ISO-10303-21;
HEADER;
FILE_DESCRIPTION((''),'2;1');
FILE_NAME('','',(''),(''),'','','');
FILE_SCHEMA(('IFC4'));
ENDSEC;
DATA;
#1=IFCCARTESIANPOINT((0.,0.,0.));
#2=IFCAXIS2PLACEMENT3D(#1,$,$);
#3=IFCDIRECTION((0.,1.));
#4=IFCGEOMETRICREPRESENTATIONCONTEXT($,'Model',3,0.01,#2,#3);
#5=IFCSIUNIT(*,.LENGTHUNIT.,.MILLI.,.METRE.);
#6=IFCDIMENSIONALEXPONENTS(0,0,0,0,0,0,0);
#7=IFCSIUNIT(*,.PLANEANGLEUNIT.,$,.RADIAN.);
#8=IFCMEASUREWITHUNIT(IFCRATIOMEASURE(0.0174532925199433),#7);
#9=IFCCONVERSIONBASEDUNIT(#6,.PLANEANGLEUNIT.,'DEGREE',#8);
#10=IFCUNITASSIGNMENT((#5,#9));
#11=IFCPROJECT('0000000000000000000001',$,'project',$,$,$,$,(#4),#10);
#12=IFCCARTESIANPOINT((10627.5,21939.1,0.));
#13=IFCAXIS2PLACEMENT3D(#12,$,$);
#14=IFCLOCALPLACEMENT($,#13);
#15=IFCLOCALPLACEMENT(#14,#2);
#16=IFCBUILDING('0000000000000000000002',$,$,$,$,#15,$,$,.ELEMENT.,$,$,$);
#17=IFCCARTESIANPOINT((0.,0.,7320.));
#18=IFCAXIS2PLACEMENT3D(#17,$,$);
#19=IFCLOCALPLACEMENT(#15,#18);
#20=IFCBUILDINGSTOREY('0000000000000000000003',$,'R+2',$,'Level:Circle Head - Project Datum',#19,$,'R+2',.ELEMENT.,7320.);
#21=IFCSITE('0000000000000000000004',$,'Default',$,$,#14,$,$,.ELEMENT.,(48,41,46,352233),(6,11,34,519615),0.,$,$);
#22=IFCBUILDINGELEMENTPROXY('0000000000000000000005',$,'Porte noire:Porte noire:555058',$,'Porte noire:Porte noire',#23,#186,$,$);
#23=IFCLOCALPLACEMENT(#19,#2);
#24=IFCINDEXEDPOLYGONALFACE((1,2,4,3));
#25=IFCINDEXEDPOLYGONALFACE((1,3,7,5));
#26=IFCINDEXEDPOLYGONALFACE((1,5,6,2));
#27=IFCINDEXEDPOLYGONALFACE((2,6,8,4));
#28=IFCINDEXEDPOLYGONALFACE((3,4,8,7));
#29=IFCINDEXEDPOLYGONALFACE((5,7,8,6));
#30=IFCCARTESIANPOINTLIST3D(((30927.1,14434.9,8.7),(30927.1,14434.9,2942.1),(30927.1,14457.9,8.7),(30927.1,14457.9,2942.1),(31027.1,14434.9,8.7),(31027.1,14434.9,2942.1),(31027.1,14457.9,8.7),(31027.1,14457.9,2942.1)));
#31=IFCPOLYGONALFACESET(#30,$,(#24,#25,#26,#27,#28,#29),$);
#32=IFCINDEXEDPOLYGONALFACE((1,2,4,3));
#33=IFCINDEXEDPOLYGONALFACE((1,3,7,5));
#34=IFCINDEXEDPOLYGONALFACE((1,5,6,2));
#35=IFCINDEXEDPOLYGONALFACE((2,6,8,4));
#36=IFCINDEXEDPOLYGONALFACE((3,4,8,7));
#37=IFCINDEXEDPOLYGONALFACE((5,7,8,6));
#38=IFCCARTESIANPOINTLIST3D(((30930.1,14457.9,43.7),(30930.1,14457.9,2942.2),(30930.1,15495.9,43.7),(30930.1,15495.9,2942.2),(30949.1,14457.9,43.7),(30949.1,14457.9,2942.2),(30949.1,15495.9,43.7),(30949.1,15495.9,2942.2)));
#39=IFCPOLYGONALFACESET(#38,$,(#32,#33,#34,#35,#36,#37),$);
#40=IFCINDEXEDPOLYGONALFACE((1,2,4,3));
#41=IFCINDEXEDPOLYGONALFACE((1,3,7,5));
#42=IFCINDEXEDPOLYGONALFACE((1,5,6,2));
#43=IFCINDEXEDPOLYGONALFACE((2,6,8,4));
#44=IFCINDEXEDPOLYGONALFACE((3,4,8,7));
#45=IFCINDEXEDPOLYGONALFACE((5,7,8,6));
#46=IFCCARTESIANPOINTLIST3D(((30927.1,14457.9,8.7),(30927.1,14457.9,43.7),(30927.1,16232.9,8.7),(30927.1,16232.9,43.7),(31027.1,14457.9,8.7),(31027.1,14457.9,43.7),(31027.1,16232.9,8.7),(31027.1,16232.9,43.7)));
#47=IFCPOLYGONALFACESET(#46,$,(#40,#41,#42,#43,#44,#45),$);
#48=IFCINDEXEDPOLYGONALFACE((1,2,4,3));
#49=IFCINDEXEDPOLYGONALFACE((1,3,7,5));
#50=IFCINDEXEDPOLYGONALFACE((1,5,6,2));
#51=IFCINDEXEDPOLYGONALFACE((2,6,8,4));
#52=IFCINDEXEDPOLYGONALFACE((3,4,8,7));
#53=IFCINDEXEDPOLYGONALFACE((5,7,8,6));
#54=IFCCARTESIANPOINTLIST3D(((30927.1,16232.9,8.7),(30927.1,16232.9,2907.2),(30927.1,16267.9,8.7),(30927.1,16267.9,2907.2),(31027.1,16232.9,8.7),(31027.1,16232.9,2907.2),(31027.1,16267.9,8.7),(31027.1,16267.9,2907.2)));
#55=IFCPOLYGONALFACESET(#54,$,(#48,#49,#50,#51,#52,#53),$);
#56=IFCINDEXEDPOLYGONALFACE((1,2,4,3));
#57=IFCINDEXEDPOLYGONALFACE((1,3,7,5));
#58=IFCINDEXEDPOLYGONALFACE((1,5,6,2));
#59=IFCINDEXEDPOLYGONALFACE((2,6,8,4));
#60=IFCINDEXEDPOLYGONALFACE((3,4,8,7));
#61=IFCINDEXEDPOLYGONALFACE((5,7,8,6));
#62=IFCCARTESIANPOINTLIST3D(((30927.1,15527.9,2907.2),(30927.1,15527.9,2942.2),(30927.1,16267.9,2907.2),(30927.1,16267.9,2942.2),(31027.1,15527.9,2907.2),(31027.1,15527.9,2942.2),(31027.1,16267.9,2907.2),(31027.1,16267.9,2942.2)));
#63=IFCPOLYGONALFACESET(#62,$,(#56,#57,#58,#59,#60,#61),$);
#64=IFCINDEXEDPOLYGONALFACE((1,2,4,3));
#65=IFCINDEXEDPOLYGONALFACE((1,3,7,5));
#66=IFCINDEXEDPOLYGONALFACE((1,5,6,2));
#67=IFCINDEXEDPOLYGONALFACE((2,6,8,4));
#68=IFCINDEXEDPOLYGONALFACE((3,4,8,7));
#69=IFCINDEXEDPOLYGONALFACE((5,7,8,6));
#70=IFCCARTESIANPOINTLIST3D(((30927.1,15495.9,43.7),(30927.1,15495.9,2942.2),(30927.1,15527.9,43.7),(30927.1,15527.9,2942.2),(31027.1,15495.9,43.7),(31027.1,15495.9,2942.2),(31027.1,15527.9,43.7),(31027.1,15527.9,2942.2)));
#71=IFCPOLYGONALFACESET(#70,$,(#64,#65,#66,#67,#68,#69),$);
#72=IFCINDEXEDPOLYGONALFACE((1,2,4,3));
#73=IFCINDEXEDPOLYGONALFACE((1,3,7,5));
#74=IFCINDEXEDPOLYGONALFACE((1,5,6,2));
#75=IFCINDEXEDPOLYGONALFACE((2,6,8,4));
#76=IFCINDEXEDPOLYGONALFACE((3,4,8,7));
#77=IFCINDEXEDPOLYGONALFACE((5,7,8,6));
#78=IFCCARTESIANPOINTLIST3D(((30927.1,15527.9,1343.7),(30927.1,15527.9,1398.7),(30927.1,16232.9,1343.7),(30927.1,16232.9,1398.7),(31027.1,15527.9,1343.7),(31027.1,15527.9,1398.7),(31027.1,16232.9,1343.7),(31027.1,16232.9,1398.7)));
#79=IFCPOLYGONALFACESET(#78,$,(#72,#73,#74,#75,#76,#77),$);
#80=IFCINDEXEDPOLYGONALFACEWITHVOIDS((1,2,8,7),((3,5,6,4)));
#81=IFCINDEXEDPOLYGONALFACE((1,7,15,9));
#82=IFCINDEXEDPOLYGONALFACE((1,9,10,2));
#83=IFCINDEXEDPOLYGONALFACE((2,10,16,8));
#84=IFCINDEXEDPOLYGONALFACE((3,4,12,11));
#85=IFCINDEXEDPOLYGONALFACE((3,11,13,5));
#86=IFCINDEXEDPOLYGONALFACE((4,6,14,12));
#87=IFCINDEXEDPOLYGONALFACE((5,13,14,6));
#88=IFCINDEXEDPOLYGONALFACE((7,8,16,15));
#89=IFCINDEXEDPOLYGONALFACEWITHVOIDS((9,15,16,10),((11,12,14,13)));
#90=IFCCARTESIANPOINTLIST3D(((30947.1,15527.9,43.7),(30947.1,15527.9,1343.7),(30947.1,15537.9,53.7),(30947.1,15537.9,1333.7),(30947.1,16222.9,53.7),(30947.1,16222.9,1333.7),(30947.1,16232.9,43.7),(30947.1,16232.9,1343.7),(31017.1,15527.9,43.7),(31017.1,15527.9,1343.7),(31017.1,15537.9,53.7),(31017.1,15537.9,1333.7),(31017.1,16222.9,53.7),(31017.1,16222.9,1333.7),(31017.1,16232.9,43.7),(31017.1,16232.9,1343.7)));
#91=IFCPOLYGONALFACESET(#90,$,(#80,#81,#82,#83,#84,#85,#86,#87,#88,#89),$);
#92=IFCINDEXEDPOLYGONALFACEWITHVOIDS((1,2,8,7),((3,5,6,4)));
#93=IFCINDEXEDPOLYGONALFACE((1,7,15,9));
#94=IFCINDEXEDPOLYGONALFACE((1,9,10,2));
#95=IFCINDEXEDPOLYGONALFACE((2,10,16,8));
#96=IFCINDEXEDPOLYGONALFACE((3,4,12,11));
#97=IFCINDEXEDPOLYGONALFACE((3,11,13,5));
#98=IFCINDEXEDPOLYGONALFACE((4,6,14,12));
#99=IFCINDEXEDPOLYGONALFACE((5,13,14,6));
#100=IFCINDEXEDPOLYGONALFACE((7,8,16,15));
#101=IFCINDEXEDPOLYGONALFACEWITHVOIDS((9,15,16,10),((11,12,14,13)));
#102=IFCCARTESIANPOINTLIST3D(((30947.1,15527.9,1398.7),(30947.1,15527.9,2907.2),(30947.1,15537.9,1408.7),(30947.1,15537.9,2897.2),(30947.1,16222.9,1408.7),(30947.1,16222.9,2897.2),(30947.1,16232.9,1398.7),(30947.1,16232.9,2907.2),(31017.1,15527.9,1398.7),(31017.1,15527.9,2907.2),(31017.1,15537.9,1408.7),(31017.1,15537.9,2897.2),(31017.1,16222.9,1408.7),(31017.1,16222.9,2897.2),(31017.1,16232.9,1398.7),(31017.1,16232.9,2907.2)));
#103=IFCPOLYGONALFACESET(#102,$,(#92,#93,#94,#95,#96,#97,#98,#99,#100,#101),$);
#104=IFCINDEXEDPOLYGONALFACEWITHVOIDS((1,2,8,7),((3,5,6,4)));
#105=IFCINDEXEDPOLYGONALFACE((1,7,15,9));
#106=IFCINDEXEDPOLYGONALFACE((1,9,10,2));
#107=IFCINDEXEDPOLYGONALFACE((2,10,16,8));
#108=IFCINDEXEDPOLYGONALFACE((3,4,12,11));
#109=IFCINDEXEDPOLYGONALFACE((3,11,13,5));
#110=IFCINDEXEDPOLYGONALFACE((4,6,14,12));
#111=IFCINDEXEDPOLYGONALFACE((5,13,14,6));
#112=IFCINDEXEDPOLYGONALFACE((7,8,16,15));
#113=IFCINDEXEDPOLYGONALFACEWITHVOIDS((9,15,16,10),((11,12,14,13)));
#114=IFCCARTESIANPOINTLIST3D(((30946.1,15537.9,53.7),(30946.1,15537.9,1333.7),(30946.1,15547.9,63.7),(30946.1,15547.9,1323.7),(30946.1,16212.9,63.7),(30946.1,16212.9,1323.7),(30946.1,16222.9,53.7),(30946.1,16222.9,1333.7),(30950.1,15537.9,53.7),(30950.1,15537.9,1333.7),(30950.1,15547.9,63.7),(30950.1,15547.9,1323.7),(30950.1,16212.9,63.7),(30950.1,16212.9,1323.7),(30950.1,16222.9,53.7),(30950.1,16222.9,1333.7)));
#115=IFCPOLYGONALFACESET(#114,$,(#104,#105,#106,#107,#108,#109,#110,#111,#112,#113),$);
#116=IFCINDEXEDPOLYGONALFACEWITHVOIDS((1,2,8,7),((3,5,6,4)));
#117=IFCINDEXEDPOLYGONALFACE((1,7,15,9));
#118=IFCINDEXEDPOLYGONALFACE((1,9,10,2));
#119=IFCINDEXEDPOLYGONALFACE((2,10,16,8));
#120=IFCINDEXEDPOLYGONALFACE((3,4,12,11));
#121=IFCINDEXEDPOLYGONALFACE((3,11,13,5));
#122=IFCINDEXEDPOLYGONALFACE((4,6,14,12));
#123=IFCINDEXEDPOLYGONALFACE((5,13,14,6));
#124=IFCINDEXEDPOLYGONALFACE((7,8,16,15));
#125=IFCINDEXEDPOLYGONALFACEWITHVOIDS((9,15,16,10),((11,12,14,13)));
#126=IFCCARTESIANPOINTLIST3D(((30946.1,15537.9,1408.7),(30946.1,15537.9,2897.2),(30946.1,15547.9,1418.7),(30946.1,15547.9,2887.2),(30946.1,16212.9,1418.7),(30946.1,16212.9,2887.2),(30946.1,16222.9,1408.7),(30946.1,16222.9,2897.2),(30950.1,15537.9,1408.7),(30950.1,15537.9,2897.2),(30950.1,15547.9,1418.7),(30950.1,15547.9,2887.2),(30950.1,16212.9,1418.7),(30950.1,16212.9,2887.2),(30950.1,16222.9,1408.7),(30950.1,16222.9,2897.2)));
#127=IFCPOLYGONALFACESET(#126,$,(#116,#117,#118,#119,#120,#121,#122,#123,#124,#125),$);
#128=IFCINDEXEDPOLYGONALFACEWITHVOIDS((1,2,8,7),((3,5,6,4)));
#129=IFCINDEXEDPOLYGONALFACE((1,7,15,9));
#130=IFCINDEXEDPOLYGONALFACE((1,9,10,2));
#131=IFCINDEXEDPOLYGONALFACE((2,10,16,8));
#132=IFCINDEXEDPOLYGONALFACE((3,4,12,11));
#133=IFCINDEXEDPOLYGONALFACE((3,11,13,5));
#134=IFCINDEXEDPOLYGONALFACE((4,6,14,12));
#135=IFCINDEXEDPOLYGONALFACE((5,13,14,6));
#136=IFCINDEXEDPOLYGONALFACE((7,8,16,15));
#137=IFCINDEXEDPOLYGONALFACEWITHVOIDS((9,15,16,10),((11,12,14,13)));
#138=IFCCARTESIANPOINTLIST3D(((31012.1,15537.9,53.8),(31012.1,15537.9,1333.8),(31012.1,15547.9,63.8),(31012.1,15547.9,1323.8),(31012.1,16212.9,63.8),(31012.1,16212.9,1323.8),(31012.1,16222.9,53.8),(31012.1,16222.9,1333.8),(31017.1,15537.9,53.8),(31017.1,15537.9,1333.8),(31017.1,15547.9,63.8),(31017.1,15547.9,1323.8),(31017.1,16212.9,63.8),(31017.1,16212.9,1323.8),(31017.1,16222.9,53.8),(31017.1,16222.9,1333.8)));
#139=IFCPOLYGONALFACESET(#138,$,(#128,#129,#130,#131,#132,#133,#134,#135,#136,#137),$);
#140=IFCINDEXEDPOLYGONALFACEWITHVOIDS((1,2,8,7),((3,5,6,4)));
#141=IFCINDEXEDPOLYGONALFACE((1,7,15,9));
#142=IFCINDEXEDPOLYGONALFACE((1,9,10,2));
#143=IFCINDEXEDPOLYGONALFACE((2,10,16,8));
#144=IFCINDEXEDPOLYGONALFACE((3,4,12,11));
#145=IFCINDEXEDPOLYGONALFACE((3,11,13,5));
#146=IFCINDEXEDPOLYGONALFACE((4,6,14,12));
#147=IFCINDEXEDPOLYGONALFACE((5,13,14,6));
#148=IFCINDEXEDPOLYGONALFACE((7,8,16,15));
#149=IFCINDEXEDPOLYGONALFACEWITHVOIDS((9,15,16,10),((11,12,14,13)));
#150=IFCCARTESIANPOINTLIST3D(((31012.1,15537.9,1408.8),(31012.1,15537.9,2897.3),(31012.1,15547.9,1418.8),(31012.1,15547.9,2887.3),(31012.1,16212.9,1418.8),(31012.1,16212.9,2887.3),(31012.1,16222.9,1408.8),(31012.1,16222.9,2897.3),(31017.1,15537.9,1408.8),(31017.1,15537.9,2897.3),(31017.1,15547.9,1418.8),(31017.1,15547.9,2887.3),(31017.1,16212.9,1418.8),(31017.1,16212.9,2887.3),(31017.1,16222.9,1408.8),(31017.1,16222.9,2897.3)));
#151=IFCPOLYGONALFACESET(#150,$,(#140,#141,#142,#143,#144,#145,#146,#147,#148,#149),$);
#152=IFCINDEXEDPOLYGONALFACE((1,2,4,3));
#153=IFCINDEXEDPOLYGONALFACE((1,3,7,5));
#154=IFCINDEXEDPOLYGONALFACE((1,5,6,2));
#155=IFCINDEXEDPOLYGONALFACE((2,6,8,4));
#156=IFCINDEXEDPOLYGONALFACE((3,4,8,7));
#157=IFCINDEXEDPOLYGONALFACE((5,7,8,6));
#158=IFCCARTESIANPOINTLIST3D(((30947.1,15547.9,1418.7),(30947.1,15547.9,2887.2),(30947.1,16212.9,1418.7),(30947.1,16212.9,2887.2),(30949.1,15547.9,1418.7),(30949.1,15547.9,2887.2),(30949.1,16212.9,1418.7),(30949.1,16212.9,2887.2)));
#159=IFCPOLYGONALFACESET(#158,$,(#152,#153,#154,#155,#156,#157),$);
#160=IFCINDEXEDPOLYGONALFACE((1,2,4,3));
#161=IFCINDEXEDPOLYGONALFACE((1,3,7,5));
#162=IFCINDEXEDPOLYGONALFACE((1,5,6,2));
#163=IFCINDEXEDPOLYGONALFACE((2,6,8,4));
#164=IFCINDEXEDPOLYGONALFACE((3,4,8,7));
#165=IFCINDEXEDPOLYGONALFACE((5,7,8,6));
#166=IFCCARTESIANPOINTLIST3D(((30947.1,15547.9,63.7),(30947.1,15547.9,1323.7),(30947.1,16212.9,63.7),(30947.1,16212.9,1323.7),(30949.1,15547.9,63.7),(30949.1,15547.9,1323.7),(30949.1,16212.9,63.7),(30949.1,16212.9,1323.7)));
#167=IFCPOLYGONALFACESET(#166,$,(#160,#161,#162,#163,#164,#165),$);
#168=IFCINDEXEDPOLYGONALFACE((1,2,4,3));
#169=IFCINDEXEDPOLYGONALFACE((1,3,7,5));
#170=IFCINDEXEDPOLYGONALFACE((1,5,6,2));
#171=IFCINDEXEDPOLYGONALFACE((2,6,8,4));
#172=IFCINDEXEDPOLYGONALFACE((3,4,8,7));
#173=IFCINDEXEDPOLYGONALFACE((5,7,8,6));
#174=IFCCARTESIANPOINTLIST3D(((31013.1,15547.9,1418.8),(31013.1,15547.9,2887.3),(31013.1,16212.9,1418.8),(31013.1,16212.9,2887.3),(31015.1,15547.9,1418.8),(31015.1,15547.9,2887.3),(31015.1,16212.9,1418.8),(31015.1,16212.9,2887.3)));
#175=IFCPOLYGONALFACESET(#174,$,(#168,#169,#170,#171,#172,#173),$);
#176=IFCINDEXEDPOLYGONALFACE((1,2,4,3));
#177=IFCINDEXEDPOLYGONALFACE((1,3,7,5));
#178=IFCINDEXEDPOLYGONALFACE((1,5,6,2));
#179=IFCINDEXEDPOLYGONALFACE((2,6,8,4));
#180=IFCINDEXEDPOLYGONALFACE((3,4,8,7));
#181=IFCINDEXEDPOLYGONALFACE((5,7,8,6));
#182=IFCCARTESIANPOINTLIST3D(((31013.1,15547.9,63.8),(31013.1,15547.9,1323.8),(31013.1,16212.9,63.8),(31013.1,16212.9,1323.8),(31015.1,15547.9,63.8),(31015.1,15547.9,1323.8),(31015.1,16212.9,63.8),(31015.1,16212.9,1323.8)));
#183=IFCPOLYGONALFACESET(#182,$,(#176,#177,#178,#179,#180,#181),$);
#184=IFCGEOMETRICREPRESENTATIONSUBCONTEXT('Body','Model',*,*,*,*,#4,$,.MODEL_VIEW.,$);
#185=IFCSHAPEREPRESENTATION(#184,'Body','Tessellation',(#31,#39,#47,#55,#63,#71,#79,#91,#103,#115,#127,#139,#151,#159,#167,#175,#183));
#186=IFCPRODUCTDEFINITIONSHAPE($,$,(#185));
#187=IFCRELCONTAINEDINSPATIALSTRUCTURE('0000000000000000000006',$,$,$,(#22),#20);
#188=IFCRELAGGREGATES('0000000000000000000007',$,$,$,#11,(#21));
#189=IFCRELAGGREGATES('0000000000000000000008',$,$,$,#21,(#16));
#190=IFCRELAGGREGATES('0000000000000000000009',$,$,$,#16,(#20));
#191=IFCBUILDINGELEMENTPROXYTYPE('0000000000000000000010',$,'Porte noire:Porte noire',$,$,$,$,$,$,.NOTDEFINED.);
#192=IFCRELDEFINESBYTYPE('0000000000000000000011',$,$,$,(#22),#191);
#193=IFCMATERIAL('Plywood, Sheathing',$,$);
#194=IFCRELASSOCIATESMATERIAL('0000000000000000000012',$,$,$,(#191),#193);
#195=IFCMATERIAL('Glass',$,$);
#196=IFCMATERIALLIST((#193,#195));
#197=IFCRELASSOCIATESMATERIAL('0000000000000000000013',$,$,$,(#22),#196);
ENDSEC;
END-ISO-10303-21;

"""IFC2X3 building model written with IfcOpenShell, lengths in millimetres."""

from ifc_helpers import new_model, entity, si_unit, converted_unit, direction, frame, frame_2d, origin, origin_2d_with_axis, place, context, subcontext, project, spatial, polyline, rectangle, outline, extrude, source, transform, mapped, material, material_list, type_object, type_shapes, element, save


model = new_model("IFC2X3")

# Units and contexts
model_context = context("Model", 3, precision=0.01, world=origin(), true_north=direction((0.0, 1.0)))
body_context = subcontext(model_context, "Body", "Model", "MODEL_VIEW")
ifc_project = project(units=[si_unit("LENGTHUNIT", "METRE", prefix="MILLI"), converted_unit("PLANEANGLEUNIT", "DEGREE", entity("IfcRatioMeasure", 0.0174532925199433), si_unit("PLANEANGLEUNIT", "RADIAN"), dimensions=[0, 0, 0, 0, 0, 0, 0])], contexts=[model_context])

# Site, building, storey
site_placement = place(None, frame((10627.5, 21939.1, 0.0)))
site = spatial("IfcSite", under=ifc_project, at=site_placement, Name="Default", CompositionType="ELEMENT", RefLatitude=(48, 41, 46, 352233), RefLongitude=(6, 11, 34, 519615), RefElevation=0.0)
building_placement = place(site_placement, origin())
building = spatial("IfcBuilding", under=site, at=building_placement, CompositionType="ELEMENT")
storey_placement = place(building_placement, frame((0.0, 0.0, 7320.0)))
storey = spatial("IfcBuildingStorey", under=building, at=storey_placement, Name="R+2", ObjectType="Level:Circle Head - Project Datum", LongName="R+2", CompositionType="ELEMENT", Elevation=7320.0)

# Building element proxy
ifc_material_1 = material(Name="Glass")
ifc_material_2 = material(Name="Plywood, Sheathing")
building_element_proxy_type_1 = type_object("IfcBuildingElementProxyType", Name="Porte noire:Porte noire", PredefinedType="NOTDEFINED", material=ifc_material_2)
shared_shape_1 = source(origin(), body_context, "Body", "SweptSolid", [
    extrude(rectangle(XDim=23.0, YDim=100.0, at=frame_2d((0.0, 0.0), x_axis=(1.0, 0.0))), frame((-950.9, 50.0, 8.7), z_axis=(0.0, 0.0, 1.0), x_axis=(-1.0, 0.0, 0.0)), (0.0, 0.0, 1.0), 2933.3),
    extrude(rectangle(XDim=1038.0, YDim=19.0, at=frame_2d((0.0, 0.0), x_axis=(1.0, 0.0))), frame((-420.4, 87.5, 43.7), z_axis=(0.0, 0.0, 1.0), x_axis=(-1.0, 0.0, 0.0)), (0.0, 0.0, 1.0), 2898.5),
    extrude(rectangle(XDim=1775.0, YDim=100.0, at=origin_2d_with_axis()), frame((-51.9, 50.0, 8.7), z_axis=(0.0, 0.0, 1.0), x_axis=(-1.0, 0.0, 0.0)), (0.0, 0.0, 1.0), 35.0),
    extrude(rectangle(XDim=35.0, YDim=100.0, at=origin_2d_with_axis()), frame((853.1, 50.0, 8.7), z_axis=(0.0, 0.0, 1.0), x_axis=(-1.0, 0.0, 0.0)), (0.0, 0.0, 1.0), 2898.5),
    extrude(rectangle(XDim=740.0, YDim=100.0, at=origin_2d_with_axis()), frame((500.6, 50.0, 2907.2), z_axis=(0.0, 0.0, 1.0), x_axis=(-1.0, 0.0, 0.0)), (0.0, 0.0, 1.0), 35.0),
    extrude(rectangle(XDim=32.0, YDim=100.0, at=origin_2d_with_axis()), frame((114.6, 50.0, 43.7), z_axis=(0.0, 0.0, 1.0), x_axis=(-1.0, 0.0, 0.0)), (0.0, 0.0, 1.0), 2898.5),
    extrude(rectangle(XDim=705.0, YDim=100.0, at=origin_2d_with_axis()), frame((483.1, 50.0, 1343.7), z_axis=(0.0, 0.0, 1.0), x_axis=(-1.0, 0.0, 0.0)), (0.0, 0.0, 1.0), 55.0),
    extrude(outline(polyline([(-352.5, -650.0), (352.5, -650.0), (352.5, 650.0), (-352.5, 650.0), (-352.5, -650.0)]), holes=[polyline([(342.5, 640.0), (342.5, -640.0), (-342.5, -640.0), (-342.5, 640.0), (342.5, 640.0)])]), frame((483.1, 10.0, 693.7), z_axis=(0.0, 1.0, 0.0), x_axis=(1.0, 0.0, 0.0)), (0.0, 0.0, 1.0), 70.0),
    extrude(outline(polyline([(-754.2, -352.5), (754.2, -352.5), (754.2, 352.5), (-754.2, 352.5), (-754.2, -352.5)]), holes=[polyline([(744.2, 342.5), (744.2, -342.5), (-744.2, -342.5), (-744.2, 342.5), (744.2, 342.5)])]), frame((483.1, 10.0, 2153.0), z_axis=(0.0, 1.0, 0.0), x_axis=(0.0, 0.0, 1.0)), (0.0, 0.0, 1.0), 70.0),
    extrude(outline(polyline([(-640.0, -342.5), (640.0, -342.5), (640.0, 342.5), (-640.0, 342.5), (-640.0, -342.5)]), holes=[polyline([(630.0, 332.5), (630.0, -332.5), (-630.0, -332.5), (-630.0, 332.5), (630.0, 332.5)])]), frame((483.1, 77.0, 693.7), z_axis=(0.0, 1.0, 0.0), x_axis=(0.0, 0.0, 1.0)), (0.0, 0.0, 1.0), 4.0),
    extrude(outline(polyline([(-744.2, -342.5), (744.2, -342.5), (744.2, 342.5), (-744.2, 342.5), (-744.2, -342.5)]), holes=[polyline([(734.2, 332.5), (734.2, -332.5), (-734.2, -332.5), (-734.2, 332.5), (734.2, 332.5)])]), frame((483.1, 77.0, 2153.0), z_axis=(0.0, 1.0, 0.0), x_axis=(0.0, 0.0, 1.0)), (0.0, 0.0, 1.0), 4.0),
    extrude(outline(polyline([(-640.0, -342.5), (640.0, -342.5), (640.0, 342.5), (-640.0, 342.5), (-640.0, -342.5)]), holes=[polyline([(630.0, 332.5), (630.0, -332.5), (-630.0, -332.5), (-630.0, 332.5), (630.0, 332.5)])]), frame((483.1, 10.0, 693.8), z_axis=(0.0, 1.0, 0.0), x_axis=(0.0, 0.0, 1.0)), (0.0, 0.0, 1.0), 5.0),
    extrude(outline(polyline([(-744.2, -342.5), (744.2, -342.5), (744.2, 342.5), (-744.2, 342.5), (-744.2, -342.5)]), holes=[polyline([(734.2, 332.5), (734.2, -332.5), (-734.2, -332.5), (-734.2, 332.5), (734.2, 332.5)])]), frame((483.1, 10.0, 2153.0), z_axis=(0.0, 1.0, 0.0), x_axis=(0.0, 0.0, 1.0)), (0.0, 0.0, 1.0), 5.0),
    extrude(rectangle(XDim=665.0, YDim=2.0, at=frame_2d((0.0, 0.0), x_axis=(1.0, 0.0))), frame((483.1, 79.0, 1418.7), z_axis=(0.0, 0.0, 1.0), x_axis=(-1.0, 0.0, 0.0)), (0.0, 0.0, 1.0), 1468.5),
    extrude(rectangle(XDim=665.0, YDim=2.0, at=frame_2d((0.0, 0.0), x_axis=(1.0, 0.0))), frame((483.1, 79.0, 63.7), z_axis=(0.0, 0.0, 1.0), x_axis=(-1.0, 0.0, 0.0)), (0.0, 0.0, 1.0), 1260.0),
    extrude(rectangle(XDim=665.0, YDim=2.0, at=frame_2d((0.0, 0.0), x_axis=(1.0, 0.0))), frame((483.1, 13.0, 1418.8), z_axis=(0.0, 0.0, 1.0), x_axis=(-1.0, 0.0, 0.0)), (0.0, 0.0, 1.0), 1468.5),
    extrude(rectangle(XDim=665.0, YDim=2.0, at=frame_2d((0.0, 0.0), x_axis=(1.0, 0.0))), frame((483.1, 13.0, 63.8), z_axis=(0.0, 0.0, 1.0), x_axis=(-1.0, 0.0, 0.0)), (0.0, 0.0, 1.0), 1260.0),
])
type_shapes(building_element_proxy_type_1, [shared_shape_1])
ifc_material_list_1 = material_list([ifc_material_2, ifc_material_1])
proxy_1_placement = place(storey_placement, frame((31027.1, 15397.3, 0.0), z_axis=(0.0, 0.0, 1.0), x_axis=(0.0, 1.0, 0.0)))
element("IfcBuildingElementProxy", 1, at=proxy_1_placement, inside=storey, type_object=building_element_proxy_type_1, material=ifc_material_list_1, Name="Porte noire:Porte noire:555058", ObjectType="Porte noire:Porte noire", context=body_context, shape_type="MappedRepresentation", body=[
    mapped(shared_shape_1, transform((0.0, 0.0, 0.0), scale=1.0)),
])

save(model, "model.ifc")
